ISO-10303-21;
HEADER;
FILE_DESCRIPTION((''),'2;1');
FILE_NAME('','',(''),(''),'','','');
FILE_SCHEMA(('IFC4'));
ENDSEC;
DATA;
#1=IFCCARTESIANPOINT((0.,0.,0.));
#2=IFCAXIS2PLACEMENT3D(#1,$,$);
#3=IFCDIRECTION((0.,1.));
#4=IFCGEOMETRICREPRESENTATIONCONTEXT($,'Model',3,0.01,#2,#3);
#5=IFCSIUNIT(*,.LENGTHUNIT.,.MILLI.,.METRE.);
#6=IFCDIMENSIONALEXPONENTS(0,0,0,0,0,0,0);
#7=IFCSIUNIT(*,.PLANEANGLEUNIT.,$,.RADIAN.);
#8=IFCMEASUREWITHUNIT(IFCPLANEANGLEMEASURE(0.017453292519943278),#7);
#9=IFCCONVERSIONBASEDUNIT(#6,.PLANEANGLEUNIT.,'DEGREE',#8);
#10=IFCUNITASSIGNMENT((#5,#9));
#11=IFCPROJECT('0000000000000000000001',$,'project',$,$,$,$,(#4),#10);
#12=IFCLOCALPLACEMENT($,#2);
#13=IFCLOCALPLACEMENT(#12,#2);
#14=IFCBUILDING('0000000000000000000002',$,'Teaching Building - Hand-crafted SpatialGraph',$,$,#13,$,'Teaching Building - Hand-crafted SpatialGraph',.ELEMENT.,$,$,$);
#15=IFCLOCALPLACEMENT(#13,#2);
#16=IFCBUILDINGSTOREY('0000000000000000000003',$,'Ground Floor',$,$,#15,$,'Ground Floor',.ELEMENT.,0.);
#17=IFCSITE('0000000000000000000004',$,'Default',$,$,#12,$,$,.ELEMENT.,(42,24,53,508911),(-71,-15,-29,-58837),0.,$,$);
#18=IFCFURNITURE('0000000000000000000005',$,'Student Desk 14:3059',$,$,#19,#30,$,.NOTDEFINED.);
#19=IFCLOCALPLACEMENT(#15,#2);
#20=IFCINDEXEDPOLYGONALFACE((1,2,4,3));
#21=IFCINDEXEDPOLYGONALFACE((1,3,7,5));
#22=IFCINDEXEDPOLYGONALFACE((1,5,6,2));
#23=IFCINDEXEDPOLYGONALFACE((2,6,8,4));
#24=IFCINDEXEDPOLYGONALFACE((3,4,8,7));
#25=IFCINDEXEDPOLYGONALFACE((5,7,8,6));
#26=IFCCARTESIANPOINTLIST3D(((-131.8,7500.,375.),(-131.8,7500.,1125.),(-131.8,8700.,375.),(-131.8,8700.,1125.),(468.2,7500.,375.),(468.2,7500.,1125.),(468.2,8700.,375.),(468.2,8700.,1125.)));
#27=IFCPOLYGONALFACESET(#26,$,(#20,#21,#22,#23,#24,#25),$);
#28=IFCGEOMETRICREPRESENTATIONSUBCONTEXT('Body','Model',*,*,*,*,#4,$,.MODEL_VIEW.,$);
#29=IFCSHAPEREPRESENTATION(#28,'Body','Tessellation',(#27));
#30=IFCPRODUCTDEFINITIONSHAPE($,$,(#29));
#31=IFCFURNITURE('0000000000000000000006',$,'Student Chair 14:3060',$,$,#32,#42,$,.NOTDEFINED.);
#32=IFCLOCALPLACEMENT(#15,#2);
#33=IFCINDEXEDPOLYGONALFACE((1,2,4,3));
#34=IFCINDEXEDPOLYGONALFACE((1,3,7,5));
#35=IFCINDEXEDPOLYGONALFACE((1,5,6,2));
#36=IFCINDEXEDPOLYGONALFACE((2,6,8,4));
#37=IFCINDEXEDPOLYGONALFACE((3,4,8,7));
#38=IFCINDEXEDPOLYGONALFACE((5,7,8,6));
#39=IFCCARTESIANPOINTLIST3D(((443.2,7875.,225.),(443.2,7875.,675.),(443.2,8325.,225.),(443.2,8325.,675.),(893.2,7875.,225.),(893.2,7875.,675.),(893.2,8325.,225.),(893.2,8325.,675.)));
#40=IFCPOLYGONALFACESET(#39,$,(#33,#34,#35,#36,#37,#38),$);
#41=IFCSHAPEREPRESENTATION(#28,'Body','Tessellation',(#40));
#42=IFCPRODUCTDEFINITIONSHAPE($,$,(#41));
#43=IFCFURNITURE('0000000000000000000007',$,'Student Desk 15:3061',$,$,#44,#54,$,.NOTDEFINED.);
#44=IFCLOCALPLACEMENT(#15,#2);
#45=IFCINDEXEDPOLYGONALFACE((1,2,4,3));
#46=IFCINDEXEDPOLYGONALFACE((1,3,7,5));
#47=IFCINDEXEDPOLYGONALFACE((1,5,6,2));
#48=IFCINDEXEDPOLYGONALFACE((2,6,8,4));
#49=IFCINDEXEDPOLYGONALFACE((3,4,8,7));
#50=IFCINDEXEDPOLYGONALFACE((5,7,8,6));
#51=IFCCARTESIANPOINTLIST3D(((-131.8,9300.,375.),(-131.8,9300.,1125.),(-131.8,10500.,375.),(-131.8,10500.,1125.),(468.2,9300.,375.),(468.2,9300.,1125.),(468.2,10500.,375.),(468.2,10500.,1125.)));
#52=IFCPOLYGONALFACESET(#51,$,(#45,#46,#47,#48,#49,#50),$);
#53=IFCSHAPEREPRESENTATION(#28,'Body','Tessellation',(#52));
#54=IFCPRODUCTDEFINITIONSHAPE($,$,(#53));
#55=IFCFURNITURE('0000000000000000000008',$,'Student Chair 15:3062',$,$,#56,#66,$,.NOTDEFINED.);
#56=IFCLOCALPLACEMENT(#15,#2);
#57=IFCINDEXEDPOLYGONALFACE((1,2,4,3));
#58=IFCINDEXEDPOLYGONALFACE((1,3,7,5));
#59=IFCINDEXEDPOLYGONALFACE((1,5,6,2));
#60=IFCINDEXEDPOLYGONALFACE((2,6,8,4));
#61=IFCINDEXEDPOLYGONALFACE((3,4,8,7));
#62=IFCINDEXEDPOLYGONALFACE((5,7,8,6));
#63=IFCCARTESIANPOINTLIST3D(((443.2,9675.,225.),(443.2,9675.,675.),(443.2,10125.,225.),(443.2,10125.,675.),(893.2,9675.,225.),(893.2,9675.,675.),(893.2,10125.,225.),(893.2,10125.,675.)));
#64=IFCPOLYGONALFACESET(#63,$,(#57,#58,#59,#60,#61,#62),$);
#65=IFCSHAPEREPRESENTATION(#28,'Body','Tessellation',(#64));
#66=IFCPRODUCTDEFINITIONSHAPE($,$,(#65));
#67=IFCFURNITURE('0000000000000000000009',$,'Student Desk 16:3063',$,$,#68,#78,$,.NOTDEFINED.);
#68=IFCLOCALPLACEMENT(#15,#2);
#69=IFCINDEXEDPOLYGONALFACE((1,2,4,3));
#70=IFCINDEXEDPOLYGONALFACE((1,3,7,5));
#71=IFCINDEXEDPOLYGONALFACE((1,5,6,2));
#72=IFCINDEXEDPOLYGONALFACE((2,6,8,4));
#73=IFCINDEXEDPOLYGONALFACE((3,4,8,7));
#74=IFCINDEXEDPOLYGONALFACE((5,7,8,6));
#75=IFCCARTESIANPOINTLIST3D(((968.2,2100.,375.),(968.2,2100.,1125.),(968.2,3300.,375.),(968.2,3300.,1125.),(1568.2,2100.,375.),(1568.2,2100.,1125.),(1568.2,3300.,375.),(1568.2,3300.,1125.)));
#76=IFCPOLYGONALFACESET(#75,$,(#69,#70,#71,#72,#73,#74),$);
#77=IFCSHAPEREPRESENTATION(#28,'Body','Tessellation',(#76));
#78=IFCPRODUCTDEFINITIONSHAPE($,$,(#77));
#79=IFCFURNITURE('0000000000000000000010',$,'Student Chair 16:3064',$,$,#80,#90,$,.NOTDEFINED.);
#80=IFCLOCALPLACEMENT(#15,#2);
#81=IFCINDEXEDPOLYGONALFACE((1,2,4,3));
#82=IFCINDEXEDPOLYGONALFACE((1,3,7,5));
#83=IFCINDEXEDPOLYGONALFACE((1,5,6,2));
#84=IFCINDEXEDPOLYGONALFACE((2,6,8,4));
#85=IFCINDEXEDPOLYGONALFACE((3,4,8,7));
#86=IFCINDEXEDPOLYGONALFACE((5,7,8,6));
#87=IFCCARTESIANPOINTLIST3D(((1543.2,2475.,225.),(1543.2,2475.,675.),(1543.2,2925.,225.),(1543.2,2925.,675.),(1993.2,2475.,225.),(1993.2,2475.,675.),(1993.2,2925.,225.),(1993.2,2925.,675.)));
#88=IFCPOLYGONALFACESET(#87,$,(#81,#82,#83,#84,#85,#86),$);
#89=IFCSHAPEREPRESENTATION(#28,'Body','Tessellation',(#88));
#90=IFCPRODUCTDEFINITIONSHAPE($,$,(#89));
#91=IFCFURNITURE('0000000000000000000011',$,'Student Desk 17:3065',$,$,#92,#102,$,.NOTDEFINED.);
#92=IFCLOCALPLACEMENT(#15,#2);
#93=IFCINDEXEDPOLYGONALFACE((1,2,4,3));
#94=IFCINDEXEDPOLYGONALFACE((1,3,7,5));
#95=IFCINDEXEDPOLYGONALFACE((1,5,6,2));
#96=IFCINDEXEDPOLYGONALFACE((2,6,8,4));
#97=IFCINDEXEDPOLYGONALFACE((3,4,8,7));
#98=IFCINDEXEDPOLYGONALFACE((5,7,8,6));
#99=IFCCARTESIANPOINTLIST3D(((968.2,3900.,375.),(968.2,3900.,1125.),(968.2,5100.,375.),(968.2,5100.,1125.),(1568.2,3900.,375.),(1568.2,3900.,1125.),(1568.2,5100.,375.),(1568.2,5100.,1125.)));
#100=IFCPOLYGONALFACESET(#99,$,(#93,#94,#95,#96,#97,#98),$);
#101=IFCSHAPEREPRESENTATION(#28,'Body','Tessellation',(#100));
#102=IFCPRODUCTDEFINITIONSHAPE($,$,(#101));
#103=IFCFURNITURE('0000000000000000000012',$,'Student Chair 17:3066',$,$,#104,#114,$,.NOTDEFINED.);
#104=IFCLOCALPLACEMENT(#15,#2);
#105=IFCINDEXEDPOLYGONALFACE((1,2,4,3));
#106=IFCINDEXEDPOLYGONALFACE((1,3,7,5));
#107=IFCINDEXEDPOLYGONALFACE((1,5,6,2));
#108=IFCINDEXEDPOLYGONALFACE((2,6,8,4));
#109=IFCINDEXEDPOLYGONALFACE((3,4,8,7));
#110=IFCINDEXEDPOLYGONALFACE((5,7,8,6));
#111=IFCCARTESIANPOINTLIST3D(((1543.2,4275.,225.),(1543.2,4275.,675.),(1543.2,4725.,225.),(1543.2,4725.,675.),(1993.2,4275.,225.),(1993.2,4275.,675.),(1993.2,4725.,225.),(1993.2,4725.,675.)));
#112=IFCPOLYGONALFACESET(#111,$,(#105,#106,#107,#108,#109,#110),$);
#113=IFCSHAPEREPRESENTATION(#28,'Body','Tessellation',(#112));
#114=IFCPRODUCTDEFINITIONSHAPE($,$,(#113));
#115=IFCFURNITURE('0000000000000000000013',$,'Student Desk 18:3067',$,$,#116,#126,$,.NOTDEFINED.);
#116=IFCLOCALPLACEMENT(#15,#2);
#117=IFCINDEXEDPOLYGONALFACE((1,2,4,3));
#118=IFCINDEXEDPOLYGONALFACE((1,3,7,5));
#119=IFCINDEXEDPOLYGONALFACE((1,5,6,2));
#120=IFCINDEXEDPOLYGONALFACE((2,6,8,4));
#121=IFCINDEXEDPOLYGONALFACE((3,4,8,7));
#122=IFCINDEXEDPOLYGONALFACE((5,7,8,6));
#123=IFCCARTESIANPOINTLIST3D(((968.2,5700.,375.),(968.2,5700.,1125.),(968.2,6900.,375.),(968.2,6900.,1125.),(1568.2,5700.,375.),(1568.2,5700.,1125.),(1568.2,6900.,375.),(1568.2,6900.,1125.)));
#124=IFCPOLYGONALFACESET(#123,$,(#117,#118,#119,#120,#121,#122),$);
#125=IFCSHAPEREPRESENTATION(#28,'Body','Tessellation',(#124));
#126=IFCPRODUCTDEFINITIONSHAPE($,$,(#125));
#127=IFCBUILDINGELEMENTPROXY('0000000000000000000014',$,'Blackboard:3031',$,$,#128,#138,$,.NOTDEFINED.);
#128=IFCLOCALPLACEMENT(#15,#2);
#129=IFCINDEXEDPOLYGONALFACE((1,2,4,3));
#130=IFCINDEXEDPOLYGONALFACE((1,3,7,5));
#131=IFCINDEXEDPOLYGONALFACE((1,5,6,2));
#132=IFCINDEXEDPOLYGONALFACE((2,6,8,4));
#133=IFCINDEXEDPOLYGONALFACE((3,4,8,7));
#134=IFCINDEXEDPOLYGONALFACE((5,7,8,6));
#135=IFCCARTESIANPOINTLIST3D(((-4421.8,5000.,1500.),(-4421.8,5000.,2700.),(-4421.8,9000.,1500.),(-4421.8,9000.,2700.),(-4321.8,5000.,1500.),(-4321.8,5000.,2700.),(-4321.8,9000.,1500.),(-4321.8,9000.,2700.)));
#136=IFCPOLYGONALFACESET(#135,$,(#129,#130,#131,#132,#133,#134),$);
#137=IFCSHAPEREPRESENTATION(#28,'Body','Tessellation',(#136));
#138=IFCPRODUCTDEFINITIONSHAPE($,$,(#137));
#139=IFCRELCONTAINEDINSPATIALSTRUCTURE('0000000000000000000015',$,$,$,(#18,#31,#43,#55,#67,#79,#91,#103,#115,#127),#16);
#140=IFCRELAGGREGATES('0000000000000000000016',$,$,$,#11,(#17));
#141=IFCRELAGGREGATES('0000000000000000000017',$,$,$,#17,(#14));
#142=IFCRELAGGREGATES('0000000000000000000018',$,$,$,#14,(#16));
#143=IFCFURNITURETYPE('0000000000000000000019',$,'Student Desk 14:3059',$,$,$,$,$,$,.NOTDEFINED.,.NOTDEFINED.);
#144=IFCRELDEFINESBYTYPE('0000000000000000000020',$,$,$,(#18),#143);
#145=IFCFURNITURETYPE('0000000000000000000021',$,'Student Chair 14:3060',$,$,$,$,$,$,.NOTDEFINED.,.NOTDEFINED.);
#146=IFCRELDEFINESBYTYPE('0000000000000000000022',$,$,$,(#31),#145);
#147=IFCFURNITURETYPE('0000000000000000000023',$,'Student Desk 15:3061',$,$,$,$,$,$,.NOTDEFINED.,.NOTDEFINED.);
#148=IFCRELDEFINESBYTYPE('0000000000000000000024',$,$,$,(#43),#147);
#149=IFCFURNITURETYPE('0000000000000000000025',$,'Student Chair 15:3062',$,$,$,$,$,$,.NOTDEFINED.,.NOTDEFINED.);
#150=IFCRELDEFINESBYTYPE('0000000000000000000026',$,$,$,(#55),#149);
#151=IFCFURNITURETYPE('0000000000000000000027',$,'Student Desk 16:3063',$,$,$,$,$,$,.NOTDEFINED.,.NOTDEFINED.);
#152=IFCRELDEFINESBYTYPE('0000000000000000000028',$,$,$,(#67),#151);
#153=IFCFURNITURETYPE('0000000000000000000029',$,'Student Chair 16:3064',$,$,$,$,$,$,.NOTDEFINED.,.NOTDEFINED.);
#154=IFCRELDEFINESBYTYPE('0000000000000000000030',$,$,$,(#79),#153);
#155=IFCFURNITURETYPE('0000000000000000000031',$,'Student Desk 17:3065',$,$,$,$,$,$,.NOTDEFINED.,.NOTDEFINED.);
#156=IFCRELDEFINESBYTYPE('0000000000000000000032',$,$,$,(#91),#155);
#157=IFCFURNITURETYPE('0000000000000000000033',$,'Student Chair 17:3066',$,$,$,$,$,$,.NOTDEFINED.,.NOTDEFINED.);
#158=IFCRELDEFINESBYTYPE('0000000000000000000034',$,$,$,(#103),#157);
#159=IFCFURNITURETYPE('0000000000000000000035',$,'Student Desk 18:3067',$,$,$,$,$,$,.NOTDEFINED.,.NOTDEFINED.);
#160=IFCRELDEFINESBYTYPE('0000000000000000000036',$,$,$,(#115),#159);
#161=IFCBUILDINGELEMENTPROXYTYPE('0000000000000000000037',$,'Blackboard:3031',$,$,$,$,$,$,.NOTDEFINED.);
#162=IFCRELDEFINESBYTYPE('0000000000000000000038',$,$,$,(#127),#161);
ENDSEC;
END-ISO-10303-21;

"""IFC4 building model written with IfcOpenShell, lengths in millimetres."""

from ifc_helpers import new_model, entity, si_unit, converted_unit, direction, frame, frame_2d, origin, origin_2d_with_axis, place, context, subcontext, project, spatial, rectangle, extrude, type_object, element, save


model = new_model("IFC4")

# Units and contexts
model_context = context("Model", 3, precision=0.01, world=origin(), true_north=direction((0.0, 1.0)))
body_context = subcontext(model_context, "Body", "Model", "MODEL_VIEW")
ifc_project = project(units=[si_unit("LENGTHUNIT", "METRE", prefix="MILLI"), converted_unit("PLANEANGLEUNIT", "DEGREE", entity("IfcPlaneAngleMeasure", 0.017453292519943278), si_unit("PLANEANGLEUNIT", "RADIAN"), dimensions=[0, 0, 0, 0, 0, 0, 0])], contexts=[model_context])

# Site, building, storey
site_placement = place(None, origin())
site = spatial("IfcSite", under=ifc_project, at=site_placement, Name="Default", CompositionType="ELEMENT", RefLatitude=(42, 24, 53, 508911), RefLongitude=(-71, -15, -29, -58837), RefElevation=0.0)
building_placement = place(site_placement, origin())
building = spatial("IfcBuilding", under=site, at=building_placement, Name="Teaching Building - Hand-crafted SpatialGraph", LongName="Teaching Building - Hand-crafted SpatialGraph", CompositionType="ELEMENT")
storey_placement = place(building_placement, origin())
storey = spatial("IfcBuildingStorey", under=building, at=storey_placement, Name="Ground Floor", LongName="Ground Floor", CompositionType="ELEMENT", Elevation=0.0)

# Furniture
furniture_type_1 = type_object("IfcFurnitureType", Name="Student Desk 14:3059", PredefinedType="NOTDEFINED")
furniture_1_placement = place(storey_placement, origin())
element("IfcFurniture", 1, at=furniture_1_placement, inside=storey, type_object=furniture_type_1, Name="Student Desk 14:3059", PredefinedType="NOTDEFINED", context=body_context, shape_type="SweptSolid", body=[
    extrude(rectangle(XDim=1200.0, YDim=600.0, at=origin_2d_with_axis()), frame((168.2, 8100.0, 375.0), z_axis=(0.0, 0.0, 1.0), x_axis=(0.0, 1.0, 0.0)), (0.0, 0.0, 1.0), 750.0),
])
furniture_type_2 = type_object("IfcFurnitureType", Name="Student Chair 14:3060", PredefinedType="NOTDEFINED")
furniture_2_placement = place(storey_placement, origin())
element("IfcFurniture", 2, at=furniture_2_placement, inside=storey, type_object=furniture_type_2, Name="Student Chair 14:3060", PredefinedType="NOTDEFINED", context=body_context, shape_type="SweptSolid", body=[
    extrude(rectangle(XDim=450.0, YDim=450.0, at=origin_2d_with_axis()), frame((668.2, 8100.0, 225.0)), (0.0, 0.0, 1.0), 450.0),
])
furniture_type_3 = type_object("IfcFurnitureType", Name="Student Desk 15:3061", PredefinedType="NOTDEFINED")
furniture_3_placement = place(storey_placement, origin())
element("IfcFurniture", 3, at=furniture_3_placement, inside=storey, type_object=furniture_type_3, Name="Student Desk 15:3061", PredefinedType="NOTDEFINED", context=body_context, shape_type="SweptSolid", body=[
    extrude(rectangle(XDim=1200.0, YDim=600.0, at=origin_2d_with_axis()), frame((168.2, 9900.0, 375.0), z_axis=(0.0, 0.0, 1.0), x_axis=(0.0, 1.0, 0.0)), (0.0, 0.0, 1.0), 750.0),
])
furniture_type_4 = type_object("IfcFurnitureType", Name="Student Chair 15:3062", PredefinedType="NOTDEFINED")
furniture_4_placement = place(storey_placement, origin())
element("IfcFurniture", 4, at=furniture_4_placement, inside=storey, type_object=furniture_type_4, Name="Student Chair 15:3062", PredefinedType="NOTDEFINED", context=body_context, shape_type="SweptSolid", body=[
    extrude(rectangle(XDim=450.0, YDim=450.0, at=frame_2d((0.0, 0.0), x_axis=(1.0, 0.0))), frame((668.2, 9900.0, 225.0)), (0.0, 0.0, 1.0), 450.0),
])
furniture_type_5 = type_object("IfcFurnitureType", Name="Student Desk 16:3063", PredefinedType="NOTDEFINED")
furniture_5_placement = place(storey_placement, origin())
element("IfcFurniture", 5, at=furniture_5_placement, inside=storey, type_object=furniture_type_5, Name="Student Desk 16:3063", PredefinedType="NOTDEFINED", context=body_context, shape_type="SweptSolid", body=[
    extrude(rectangle(XDim=1200.0, YDim=600.0, at=origin_2d_with_axis()), frame((1268.2, 2700.0, 375.0), z_axis=(0.0, 0.0, 1.0), x_axis=(0.0, 1.0, 0.0)), (0.0, 0.0, 1.0), 750.0),
])
furniture_type_6 = type_object("IfcFurnitureType", Name="Student Chair 16:3064", PredefinedType="NOTDEFINED")
furniture_6_placement = place(storey_placement, origin())
element("IfcFurniture", 6, at=furniture_6_placement, inside=storey, type_object=furniture_type_6, Name="Student Chair 16:3064", PredefinedType="NOTDEFINED", context=body_context, shape_type="SweptSolid", body=[
    extrude(rectangle(XDim=450.0, YDim=450.0, at=origin_2d_with_axis()), frame((1768.2, 2700.0, 225.0)), (0.0, 0.0, 1.0), 450.0),
])
furniture_type_7 = type_object("IfcFurnitureType", Name="Student Desk 17:3065", PredefinedType="NOTDEFINED")
furniture_7_placement = place(storey_placement, origin())
element("IfcFurniture", 7, at=furniture_7_placement, inside=storey, type_object=furniture_type_7, Name="Student Desk 17:3065", PredefinedType="NOTDEFINED", context=body_context, shape_type="SweptSolid", body=[
    extrude(rectangle(XDim=1200.0, YDim=600.0, at=frame_2d((0.0, 0.0), x_axis=(1.0, 0.0))), frame((1268.2, 4500.0, 375.0), z_axis=(0.0, 0.0, 1.0), x_axis=(0.0, 1.0, 0.0)), (0.0, 0.0, 1.0), 750.0),
])
furniture_type_8 = type_object("IfcFurnitureType", Name="Student Chair 17:3066", PredefinedType="NOTDEFINED")
furniture_8_placement = place(storey_placement, origin())
element("IfcFurniture", 8, at=furniture_8_placement, inside=storey, type_object=furniture_type_8, Name="Student Chair 17:3066", PredefinedType="NOTDEFINED", context=body_context, shape_type="SweptSolid", body=[
    extrude(rectangle(XDim=450.0, YDim=450.0, at=origin_2d_with_axis()), frame((1768.2, 4500.0, 225.0)), (0.0, 0.0, 1.0), 450.0),
])
furniture_type_9 = type_object("IfcFurnitureType", Name="Student Desk 18:3067", PredefinedType="NOTDEFINED")
furniture_9_placement = place(storey_placement, origin())
element("IfcFurniture", 9, at=furniture_9_placement, inside=storey, type_object=furniture_type_9, Name="Student Desk 18:3067", PredefinedType="NOTDEFINED", context=body_context, shape_type="SweptSolid", body=[
    extrude(rectangle(XDim=1200.0, YDim=600.0, at=origin_2d_with_axis()), frame((1268.2, 6300.0, 375.0), z_axis=(0.0, 0.0, 1.0), x_axis=(0.0, 1.0, 0.0)), (0.0, 0.0, 1.0), 750.0),
])

# Building element proxy
building_element_proxy_type = type_object("IfcBuildingElementProxyType", Name="Blackboard:3031", PredefinedType="NOTDEFINED")
proxy_placement = place(storey_placement, origin())
element("IfcBuildingElementProxy", 10, at=proxy_placement, inside=storey, type_object=building_element_proxy_type, Name="Blackboard:3031", PredefinedType="NOTDEFINED", context=body_context, shape_type="SweptSolid", body=[
    extrude(rectangle(XDim=100.0, YDim=4000.0, at=frame_2d((0.0, 0.0), x_axis=(1.0, 0.0))), frame((-4371.8, 7000.0, 1500.0)), (0.0, 0.0, 1.0), 1200.0),
])

save(model, "model.ifc")
